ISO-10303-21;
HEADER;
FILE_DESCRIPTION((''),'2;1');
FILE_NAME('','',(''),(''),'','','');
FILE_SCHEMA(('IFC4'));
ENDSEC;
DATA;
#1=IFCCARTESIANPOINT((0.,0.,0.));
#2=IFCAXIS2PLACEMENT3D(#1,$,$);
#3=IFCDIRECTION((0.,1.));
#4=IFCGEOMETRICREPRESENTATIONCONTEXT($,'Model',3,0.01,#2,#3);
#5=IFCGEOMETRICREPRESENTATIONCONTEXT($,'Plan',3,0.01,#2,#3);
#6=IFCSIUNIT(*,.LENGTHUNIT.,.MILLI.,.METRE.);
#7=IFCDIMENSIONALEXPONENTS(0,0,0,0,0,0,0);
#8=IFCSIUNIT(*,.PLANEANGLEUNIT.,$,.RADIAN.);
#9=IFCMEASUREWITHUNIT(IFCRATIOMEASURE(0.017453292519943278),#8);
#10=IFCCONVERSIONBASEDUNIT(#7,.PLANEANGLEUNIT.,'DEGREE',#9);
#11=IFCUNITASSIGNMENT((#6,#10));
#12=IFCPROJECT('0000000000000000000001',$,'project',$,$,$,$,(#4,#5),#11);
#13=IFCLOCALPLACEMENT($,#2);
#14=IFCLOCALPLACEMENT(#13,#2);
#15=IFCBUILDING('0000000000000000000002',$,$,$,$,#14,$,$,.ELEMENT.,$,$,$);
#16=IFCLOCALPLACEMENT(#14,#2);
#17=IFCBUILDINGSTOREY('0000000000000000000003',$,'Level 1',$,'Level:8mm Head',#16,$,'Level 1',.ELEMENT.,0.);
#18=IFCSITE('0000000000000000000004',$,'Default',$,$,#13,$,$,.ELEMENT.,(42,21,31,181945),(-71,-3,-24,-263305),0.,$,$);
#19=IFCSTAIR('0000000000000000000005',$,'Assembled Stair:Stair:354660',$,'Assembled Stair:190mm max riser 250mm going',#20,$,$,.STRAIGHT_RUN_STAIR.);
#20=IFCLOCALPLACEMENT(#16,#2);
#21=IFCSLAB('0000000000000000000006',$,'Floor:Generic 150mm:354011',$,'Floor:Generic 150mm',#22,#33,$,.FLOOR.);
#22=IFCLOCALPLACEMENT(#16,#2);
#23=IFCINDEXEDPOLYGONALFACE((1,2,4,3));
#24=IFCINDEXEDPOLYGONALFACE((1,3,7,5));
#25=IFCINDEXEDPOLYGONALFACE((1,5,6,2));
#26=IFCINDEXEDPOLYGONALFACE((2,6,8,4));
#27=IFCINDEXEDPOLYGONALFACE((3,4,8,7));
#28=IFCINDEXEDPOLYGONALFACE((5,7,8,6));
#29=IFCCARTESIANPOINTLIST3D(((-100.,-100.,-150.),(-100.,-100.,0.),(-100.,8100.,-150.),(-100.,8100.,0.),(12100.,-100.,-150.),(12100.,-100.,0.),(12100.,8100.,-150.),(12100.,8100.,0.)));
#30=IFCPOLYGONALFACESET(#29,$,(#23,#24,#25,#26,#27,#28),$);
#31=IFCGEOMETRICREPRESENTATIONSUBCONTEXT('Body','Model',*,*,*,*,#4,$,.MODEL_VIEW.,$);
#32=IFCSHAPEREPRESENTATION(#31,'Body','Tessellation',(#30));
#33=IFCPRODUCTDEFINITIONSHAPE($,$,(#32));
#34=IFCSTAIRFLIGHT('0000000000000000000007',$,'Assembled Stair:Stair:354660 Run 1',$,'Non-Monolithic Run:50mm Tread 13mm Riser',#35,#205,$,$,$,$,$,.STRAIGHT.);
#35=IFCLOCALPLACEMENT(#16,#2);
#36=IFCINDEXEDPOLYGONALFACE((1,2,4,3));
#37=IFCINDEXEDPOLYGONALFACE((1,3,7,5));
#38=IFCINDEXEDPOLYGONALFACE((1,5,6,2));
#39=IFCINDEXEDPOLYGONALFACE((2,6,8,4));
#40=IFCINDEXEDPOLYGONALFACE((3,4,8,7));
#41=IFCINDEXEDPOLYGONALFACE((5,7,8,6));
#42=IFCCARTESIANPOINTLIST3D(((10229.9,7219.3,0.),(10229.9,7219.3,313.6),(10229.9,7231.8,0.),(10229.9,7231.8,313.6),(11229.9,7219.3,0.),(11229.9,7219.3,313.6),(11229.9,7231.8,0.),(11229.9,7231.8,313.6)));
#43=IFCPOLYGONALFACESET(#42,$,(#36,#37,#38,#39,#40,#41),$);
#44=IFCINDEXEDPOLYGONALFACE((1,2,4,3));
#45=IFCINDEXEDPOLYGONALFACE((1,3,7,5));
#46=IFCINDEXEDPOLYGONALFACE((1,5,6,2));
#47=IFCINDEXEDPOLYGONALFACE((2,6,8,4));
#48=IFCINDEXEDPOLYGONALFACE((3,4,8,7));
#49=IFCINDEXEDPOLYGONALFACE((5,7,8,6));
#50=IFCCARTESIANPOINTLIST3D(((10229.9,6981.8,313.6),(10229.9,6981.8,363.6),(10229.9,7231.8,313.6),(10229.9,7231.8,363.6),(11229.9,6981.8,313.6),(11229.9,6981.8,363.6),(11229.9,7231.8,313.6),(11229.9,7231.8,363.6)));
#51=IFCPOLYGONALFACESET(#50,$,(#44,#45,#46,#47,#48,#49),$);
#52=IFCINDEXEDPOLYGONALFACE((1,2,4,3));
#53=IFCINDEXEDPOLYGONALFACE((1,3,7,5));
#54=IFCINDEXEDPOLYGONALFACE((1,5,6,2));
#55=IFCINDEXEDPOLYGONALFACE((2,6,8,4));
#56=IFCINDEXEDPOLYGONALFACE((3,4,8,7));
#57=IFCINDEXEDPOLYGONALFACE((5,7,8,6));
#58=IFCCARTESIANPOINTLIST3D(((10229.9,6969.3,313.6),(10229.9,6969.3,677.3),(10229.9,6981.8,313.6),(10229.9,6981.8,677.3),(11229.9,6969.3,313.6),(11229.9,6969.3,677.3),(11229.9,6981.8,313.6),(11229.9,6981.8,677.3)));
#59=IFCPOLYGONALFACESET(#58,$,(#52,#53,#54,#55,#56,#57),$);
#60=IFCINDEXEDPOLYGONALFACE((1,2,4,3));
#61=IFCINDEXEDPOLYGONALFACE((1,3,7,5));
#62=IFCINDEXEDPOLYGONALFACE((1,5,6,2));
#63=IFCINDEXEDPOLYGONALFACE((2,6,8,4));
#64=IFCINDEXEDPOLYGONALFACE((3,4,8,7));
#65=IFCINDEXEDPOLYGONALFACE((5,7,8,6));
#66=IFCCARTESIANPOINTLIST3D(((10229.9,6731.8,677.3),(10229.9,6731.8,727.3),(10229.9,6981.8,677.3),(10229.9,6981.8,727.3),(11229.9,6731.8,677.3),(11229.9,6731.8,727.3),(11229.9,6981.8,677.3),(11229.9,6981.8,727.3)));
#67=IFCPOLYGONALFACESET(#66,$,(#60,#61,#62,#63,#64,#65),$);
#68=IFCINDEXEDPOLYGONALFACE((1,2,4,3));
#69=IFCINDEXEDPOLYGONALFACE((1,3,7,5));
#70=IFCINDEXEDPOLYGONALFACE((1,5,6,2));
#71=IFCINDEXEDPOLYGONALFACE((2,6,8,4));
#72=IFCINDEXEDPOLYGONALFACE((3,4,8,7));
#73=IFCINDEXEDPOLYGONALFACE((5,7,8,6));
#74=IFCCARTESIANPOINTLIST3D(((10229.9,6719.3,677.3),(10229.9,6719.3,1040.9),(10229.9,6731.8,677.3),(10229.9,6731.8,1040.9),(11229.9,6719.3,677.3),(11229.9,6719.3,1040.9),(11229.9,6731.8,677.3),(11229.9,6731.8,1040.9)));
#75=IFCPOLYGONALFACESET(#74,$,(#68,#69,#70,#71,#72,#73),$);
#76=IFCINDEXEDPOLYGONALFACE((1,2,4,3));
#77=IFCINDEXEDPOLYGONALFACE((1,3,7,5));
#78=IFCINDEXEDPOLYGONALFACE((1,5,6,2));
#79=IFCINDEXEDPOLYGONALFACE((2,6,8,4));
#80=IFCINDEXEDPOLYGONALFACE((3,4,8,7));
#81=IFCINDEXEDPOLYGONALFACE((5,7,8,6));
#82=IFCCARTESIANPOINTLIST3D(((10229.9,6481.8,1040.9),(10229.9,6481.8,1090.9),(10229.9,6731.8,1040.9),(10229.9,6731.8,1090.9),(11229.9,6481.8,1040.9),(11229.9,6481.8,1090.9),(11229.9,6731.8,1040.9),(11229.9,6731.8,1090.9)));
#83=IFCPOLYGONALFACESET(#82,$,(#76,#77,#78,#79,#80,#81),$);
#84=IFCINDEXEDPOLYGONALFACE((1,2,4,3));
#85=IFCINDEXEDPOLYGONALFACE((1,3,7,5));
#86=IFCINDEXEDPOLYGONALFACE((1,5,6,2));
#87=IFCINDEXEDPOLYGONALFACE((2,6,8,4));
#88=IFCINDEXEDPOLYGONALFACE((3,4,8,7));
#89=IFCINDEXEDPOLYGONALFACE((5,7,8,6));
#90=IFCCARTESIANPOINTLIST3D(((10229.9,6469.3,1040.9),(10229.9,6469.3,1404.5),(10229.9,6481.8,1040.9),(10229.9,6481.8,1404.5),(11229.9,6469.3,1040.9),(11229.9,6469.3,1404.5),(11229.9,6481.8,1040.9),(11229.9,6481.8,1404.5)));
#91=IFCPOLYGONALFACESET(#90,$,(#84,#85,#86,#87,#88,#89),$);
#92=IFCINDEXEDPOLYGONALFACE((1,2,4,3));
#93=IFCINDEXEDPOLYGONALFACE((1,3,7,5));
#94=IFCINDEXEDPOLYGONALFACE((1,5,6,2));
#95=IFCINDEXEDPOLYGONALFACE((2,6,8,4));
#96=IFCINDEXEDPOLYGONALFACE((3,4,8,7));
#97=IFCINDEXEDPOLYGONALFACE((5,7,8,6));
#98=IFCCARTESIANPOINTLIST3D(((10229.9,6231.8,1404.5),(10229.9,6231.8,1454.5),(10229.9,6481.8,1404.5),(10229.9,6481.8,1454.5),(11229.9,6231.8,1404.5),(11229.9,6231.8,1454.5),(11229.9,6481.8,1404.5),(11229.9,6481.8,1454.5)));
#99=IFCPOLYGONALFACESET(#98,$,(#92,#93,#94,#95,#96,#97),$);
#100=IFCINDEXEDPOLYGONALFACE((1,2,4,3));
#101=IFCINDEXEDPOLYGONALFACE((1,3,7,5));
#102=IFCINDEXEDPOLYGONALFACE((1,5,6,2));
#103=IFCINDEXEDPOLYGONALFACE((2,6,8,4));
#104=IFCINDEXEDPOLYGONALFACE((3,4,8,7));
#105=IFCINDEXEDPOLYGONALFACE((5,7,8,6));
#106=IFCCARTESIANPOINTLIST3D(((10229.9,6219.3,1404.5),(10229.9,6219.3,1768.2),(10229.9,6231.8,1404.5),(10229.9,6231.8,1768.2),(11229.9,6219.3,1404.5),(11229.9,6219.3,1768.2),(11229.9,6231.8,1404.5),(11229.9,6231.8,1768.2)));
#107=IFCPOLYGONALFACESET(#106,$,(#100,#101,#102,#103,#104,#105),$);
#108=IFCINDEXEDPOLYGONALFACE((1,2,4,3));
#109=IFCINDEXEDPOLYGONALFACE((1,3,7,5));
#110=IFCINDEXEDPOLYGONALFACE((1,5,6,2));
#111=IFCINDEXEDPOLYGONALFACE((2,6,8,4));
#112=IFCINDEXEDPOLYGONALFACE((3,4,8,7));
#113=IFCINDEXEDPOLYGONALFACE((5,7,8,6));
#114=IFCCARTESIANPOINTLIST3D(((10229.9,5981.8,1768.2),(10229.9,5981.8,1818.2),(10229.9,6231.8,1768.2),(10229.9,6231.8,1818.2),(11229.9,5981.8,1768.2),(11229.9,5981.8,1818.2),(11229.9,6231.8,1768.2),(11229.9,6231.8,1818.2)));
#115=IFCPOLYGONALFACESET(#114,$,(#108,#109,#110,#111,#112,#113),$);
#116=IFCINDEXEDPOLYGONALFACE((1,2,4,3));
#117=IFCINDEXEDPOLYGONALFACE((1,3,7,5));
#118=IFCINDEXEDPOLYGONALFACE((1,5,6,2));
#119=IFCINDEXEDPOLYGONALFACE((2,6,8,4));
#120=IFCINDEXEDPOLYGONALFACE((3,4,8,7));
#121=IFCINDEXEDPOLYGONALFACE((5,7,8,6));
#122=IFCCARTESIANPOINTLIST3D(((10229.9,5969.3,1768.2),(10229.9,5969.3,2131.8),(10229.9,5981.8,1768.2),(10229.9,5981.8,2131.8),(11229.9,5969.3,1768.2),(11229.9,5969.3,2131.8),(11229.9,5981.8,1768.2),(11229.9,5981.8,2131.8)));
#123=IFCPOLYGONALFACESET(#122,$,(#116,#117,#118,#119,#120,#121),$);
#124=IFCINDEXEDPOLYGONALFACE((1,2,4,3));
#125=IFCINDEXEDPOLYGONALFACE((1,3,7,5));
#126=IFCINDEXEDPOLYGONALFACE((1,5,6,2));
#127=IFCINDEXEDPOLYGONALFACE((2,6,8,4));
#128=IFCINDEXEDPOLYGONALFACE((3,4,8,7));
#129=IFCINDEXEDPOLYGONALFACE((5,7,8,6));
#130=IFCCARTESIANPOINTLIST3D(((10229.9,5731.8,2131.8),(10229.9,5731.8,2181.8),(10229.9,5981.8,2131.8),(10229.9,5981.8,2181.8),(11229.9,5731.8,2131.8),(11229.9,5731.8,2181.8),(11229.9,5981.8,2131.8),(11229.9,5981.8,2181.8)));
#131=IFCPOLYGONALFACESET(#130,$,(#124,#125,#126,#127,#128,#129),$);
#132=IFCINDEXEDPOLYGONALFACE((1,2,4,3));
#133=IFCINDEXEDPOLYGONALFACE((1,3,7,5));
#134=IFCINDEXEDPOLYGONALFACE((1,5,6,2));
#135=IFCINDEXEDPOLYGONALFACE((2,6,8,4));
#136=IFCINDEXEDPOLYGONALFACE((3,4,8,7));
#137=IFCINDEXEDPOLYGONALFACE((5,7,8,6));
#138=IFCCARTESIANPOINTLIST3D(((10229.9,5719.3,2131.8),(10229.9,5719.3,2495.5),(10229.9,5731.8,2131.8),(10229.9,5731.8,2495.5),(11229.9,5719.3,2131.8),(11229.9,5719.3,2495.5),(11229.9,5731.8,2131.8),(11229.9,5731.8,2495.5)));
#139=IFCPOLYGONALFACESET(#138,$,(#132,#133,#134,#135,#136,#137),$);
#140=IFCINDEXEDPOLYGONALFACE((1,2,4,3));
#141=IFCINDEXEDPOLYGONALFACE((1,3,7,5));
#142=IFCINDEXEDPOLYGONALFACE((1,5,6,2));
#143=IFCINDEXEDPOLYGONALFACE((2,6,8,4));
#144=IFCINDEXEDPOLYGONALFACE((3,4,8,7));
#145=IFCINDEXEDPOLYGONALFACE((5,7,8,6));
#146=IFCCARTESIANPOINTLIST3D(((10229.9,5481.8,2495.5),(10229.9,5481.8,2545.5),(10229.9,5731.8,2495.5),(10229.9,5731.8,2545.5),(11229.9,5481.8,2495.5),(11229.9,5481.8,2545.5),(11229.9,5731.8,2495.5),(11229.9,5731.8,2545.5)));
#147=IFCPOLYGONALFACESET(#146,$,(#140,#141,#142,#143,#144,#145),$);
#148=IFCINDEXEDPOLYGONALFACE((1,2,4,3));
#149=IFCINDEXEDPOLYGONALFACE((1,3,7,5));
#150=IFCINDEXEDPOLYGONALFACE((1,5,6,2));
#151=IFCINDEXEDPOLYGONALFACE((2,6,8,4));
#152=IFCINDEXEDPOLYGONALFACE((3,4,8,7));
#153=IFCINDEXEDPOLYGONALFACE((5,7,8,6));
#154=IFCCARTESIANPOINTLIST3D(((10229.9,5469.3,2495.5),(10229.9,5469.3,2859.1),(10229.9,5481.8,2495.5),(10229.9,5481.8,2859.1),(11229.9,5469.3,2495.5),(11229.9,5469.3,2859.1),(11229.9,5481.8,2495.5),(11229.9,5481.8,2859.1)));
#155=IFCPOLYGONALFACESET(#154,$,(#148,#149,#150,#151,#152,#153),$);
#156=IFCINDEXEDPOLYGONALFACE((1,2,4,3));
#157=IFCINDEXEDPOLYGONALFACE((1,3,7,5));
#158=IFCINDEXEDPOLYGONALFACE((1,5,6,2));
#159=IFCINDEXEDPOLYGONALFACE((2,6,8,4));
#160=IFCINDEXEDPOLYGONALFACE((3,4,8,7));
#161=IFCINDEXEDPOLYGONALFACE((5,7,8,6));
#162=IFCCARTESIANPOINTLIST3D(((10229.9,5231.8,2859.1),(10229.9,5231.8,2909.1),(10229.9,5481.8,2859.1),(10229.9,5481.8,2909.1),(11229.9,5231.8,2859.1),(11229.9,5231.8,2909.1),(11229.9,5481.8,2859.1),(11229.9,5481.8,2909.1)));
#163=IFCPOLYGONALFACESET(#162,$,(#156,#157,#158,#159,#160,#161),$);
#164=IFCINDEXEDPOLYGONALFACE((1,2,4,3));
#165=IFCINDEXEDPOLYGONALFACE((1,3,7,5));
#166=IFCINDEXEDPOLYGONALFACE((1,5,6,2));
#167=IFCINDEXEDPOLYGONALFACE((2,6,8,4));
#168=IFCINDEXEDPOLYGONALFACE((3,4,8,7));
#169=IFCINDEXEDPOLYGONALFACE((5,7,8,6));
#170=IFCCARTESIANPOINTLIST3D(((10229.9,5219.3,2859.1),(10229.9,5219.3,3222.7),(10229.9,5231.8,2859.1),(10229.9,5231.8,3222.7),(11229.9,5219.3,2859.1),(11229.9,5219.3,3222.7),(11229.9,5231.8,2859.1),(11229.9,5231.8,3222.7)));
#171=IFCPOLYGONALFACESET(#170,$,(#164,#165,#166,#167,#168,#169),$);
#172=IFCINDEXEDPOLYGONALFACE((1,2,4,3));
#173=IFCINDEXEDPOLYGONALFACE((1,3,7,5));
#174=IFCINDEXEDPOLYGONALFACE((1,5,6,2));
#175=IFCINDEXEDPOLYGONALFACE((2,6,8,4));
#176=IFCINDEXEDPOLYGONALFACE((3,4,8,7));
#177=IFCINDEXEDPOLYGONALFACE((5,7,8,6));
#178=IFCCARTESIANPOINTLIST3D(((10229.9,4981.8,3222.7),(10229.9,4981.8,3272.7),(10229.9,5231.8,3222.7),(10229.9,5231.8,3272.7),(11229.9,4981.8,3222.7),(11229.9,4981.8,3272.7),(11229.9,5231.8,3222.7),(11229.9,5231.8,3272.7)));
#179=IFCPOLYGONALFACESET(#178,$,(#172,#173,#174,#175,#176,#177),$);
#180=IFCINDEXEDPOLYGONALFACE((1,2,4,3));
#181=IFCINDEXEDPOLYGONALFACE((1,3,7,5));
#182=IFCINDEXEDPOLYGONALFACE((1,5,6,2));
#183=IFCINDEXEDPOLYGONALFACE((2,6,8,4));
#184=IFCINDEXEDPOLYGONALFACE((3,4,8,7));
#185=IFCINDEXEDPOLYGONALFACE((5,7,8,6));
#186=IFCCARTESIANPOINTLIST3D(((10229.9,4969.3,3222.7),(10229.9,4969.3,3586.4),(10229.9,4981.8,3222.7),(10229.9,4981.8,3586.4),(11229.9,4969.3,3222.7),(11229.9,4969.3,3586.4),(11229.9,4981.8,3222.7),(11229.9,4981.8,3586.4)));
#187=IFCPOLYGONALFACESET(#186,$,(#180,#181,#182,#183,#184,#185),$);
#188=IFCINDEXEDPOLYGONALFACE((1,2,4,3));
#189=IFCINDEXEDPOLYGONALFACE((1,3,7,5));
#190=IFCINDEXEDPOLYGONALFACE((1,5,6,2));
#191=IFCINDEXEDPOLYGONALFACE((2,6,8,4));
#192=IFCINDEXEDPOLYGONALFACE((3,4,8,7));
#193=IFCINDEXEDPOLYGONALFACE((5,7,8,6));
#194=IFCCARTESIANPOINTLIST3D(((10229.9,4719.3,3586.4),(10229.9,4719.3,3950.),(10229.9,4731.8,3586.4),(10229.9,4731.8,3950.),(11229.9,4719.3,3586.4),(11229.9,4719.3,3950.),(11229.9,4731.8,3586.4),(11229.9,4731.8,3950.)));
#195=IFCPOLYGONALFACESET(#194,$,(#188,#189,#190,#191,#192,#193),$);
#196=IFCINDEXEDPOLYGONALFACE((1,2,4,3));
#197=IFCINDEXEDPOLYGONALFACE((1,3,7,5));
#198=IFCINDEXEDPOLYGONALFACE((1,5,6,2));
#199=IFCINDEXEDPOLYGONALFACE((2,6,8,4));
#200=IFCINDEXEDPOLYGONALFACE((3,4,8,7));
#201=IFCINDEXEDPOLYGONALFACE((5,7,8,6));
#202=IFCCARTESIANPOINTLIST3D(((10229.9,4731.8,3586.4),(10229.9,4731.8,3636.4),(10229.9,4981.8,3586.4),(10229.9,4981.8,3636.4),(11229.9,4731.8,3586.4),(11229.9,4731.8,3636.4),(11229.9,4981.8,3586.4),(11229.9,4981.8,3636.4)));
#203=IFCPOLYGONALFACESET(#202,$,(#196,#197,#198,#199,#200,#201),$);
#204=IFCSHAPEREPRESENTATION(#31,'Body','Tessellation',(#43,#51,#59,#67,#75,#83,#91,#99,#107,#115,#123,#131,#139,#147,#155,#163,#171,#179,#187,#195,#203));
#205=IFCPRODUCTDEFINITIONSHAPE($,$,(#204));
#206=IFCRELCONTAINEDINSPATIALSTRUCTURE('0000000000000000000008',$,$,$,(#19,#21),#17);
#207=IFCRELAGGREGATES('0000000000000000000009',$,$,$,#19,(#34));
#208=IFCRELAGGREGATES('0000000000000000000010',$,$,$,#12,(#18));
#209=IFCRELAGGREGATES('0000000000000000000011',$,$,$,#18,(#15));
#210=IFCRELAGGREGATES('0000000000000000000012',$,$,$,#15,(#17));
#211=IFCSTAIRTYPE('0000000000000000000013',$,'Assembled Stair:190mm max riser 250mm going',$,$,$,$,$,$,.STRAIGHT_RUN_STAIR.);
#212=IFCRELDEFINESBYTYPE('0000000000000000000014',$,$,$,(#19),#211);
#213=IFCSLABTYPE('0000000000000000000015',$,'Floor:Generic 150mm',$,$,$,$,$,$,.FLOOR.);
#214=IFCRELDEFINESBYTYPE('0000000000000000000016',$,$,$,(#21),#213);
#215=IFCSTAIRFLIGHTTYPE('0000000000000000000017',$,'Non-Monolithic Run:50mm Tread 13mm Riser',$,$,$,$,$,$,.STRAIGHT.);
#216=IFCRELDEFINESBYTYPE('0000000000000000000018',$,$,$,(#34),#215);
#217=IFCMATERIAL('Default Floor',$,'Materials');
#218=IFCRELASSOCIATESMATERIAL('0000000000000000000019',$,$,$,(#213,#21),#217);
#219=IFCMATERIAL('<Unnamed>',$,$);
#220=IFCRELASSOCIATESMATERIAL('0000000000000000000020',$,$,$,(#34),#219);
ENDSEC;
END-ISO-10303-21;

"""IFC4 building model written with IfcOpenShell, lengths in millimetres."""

from ifc_helpers import new_model, entity, si_unit, converted_unit, direction, frame, origin, place, context, subcontext, project, spatial, indexed_curve, outline, extrude, material, type_object, element, aggregate, save


model = new_model("IFC4")

# Units and contexts
model_context = context("Model", 3, precision=0.01, world=origin(), true_north=direction((0.0, 1.0)))
plan_context = context("Plan", 3, precision=0.01, world=origin(), true_north=direction((0.0, 1.0)))
body_context = subcontext(model_context, "Body", "Model", "MODEL_VIEW")
ifc_project = project(units=[si_unit("LENGTHUNIT", "METRE", prefix="MILLI"), converted_unit("PLANEANGLEUNIT", "DEGREE", entity("IfcRatioMeasure", 0.017453292519943278), si_unit("PLANEANGLEUNIT", "RADIAN"), dimensions=[0, 0, 0, 0, 0, 0, 0])], contexts=[model_context, plan_context])

# Site, building, storey
site_placement = place(None, origin())
site = spatial("IfcSite", under=ifc_project, at=site_placement, Name="Default", CompositionType="ELEMENT", RefLatitude=(42, 21, 31, 181945), RefLongitude=(-71, -3, -24, -263305), RefElevation=0.0)
building_placement = place(site_placement, origin())
building = spatial("IfcBuilding", under=site, at=building_placement, CompositionType="ELEMENT")
storey_placement = place(building_placement, origin())
storey = spatial("IfcBuildingStorey", under=building, at=storey_placement, Name="Level 1", ObjectType="Level:8mm Head", LongName="Level 1", CompositionType="ELEMENT", Elevation=0.0)

# Stair
stair_type = type_object("IfcStairType", Name="Assembled Stair:190mm max riser 250mm going", PredefinedType="STRAIGHT_RUN_STAIR")
stair_placement = place(storey_placement, origin())
stair = element("IfcStair", 1, at=stair_placement, inside=storey, type_object=stair_type, Name="Assembled Stair:Stair:354660", ObjectType="Assembled Stair:190mm max riser 250mm going", PredefinedType="STRAIGHT_RUN_STAIR")
ifc_material_1 = material(Name="<Unnamed>")

# Slab
ifc_material_2 = material(Name="Default Floor", Category="Materials")
slab_type = type_object("IfcSlabType", Name="Floor:Generic 150mm", PredefinedType="FLOOR", material=ifc_material_2)
slab_placement = place(storey_placement, origin())
element("IfcSlab", 2, at=slab_placement, inside=storey, type_object=slab_type, material=ifc_material_2, Name="Floor:Generic 150mm:354011", ObjectType="Floor:Generic 150mm", PredefinedType="FLOOR", context=body_context, shape_type="SweptSolid", body=[
    extrude(outline(indexed_curve([(-4100.0, -6100.0), (4100.0, -6100.0), (4100.0, 6100.0), (-4100.0, 6100.0), (-4100.0, -6100.0)], self_intersect=False)), frame((6000.0, 4000.0, 0.0), z_axis=(0.0, 0.0, -1.0), x_axis=(0.0, 1.0, 0.0)), (0.0, 0.0, 1.0), 150.0),
])

# Stair flight
stair_flight_type = type_object("IfcStairFlightType", Name="Non-Monolithic Run:50mm Tread 13mm Riser", PredefinedType="STRAIGHT")
stair_flight_placement = place(stair_placement, frame((10229.9, 4719.3, 0.0)))
stair_flight = element("IfcStairFlight", 3, at=stair_flight_placement, type_object=stair_flight_type, material=ifc_material_1, Name="Assembled Stair:Stair:354660 Run 1", ObjectType="Non-Monolithic Run:50mm Tread 13mm Riser", PredefinedType="STRAIGHT", context=body_context, shape_type="SweptSolid", body=[
    extrude(outline(indexed_curve([(-500.0, -6.2), (500.0, -6.2), (500.0, 6.3), (-500.0, 6.3), (-500.0, -6.2)], self_intersect=False)), frame((500.0, 2506.2, 0.0)), (0.0, 0.0, 1.0), 313.6),
    extrude(outline(indexed_curve([(-125.0, -500.0), (125.0, -500.0), (125.0, 500.0), (-125.0, 500.0), (-125.0, -500.0)], self_intersect=False)), frame((500.0, 2387.5, 313.6), z_axis=(0.0, 0.0, 1.0), x_axis=(0.0, 1.0, 0.0)), (0.0, 0.0, 1.0), 50.0),
    extrude(outline(indexed_curve([(-500.0, -6.2), (500.0, -6.2), (500.0, 6.3), (-500.0, 6.3), (-500.0, -6.2)], self_intersect=False)), frame((500.0, 2256.2, 313.6)), (0.0, 0.0, 1.0), 363.6),
    extrude(outline(indexed_curve([(-125.0, -500.0), (125.0, -500.0), (125.0, 500.0), (-125.0, 500.0), (-125.0, -500.0)], self_intersect=False)), frame((500.0, 2137.5, 677.3), z_axis=(0.0, 0.0, 1.0), x_axis=(0.0, 1.0, 0.0)), (0.0, 0.0, 1.0), 50.0),
    extrude(outline(indexed_curve([(-500.0, -6.2), (500.0, -6.2), (500.0, 6.3), (-500.0, 6.3), (-500.0, -6.2)], self_intersect=False)), frame((500.0, 2006.2, 677.3)), (0.0, 0.0, 1.0), 363.6),
    extrude(outline(indexed_curve([(-125.0, -500.0), (125.0, -500.0), (125.0, 500.0), (-125.0, 500.0), (-125.0, -500.0)], self_intersect=False)), frame((500.0, 1887.5, 1040.9), z_axis=(0.0, 0.0, 1.0), x_axis=(0.0, 1.0, 0.0)), (0.0, 0.0, 1.0), 50.0),
    extrude(outline(indexed_curve([(-500.0, -6.2), (500.0, -6.2), (500.0, 6.3), (-500.0, 6.3), (-500.0, -6.2)], self_intersect=False)), frame((500.0, 1756.2, 1040.9)), (0.0, 0.0, 1.0), 363.6),
    extrude(outline(indexed_curve([(-125.0, -500.0), (125.0, -500.0), (125.0, 500.0), (-125.0, 500.0), (-125.0, -500.0)], self_intersect=False)), frame((500.0, 1637.5, 1404.5), z_axis=(0.0, 0.0, 1.0), x_axis=(0.0, 1.0, 0.0)), (0.0, 0.0, 1.0), 50.0),
    extrude(outline(indexed_curve([(-500.0, -6.2), (500.0, -6.2), (500.0, 6.3), (-500.0, 6.3), (-500.0, -6.2)], self_intersect=False)), frame((500.0, 1506.2, 1404.5)), (0.0, 0.0, 1.0), 363.6),
    extrude(outline(indexed_curve([(-125.0, -500.0), (125.0, -500.0), (125.0, 500.0), (-125.0, 500.0), (-125.0, -500.0)], self_intersect=False)), frame((500.0, 1387.5, 1768.2), z_axis=(0.0, 0.0, 1.0), x_axis=(0.0, 1.0, 0.0)), (0.0, 0.0, 1.0), 50.0),
    extrude(outline(indexed_curve([(-500.0, -6.3), (500.0, -6.3), (500.0, 6.2), (-500.0, 6.2), (-500.0, -6.3)], self_intersect=False)), frame((500.0, 1256.3, 1768.2)), (0.0, 0.0, 1.0), 363.6),
    extrude(outline(indexed_curve([(-125.0, -500.0), (125.0, -500.0), (125.0, 500.0), (-125.0, 500.0), (-125.0, -500.0)], self_intersect=False)), frame((500.0, 1137.5, 2131.8), z_axis=(0.0, 0.0, 1.0), x_axis=(0.0, 1.0, 0.0)), (0.0, 0.0, 1.0), 50.0),
    extrude(outline(indexed_curve([(-500.0, -6.3), (500.0, -6.3), (500.0, 6.2), (-500.0, 6.2), (-500.0, -6.3)], self_intersect=False)), frame((500.0, 1006.3, 2131.8)), (0.0, 0.0, 1.0), 363.6),
    extrude(outline(indexed_curve([(-125.0, -500.0), (125.0, -500.0), (125.0, 500.0), (-125.0, 500.0), (-125.0, -500.0)], self_intersect=False)), frame((500.0, 887.5, 2495.5), z_axis=(0.0, 0.0, 1.0), x_axis=(0.0, 1.0, 0.0)), (0.0, 0.0, 1.0), 50.0),
    extrude(outline(indexed_curve([(-500.0, -6.2), (500.0, -6.2), (500.0, 6.3), (-500.0, 6.3), (-500.0, -6.2)], self_intersect=False)), frame((500.0, 756.2, 2495.5)), (0.0, 0.0, 1.0), 363.6),
    extrude(outline(indexed_curve([(-125.0, -500.0), (125.0, -500.0), (125.0, 500.0), (-125.0, 500.0), (-125.0, -500.0)], self_intersect=False)), frame((500.0, 637.5, 2859.1), z_axis=(0.0, 0.0, 1.0), x_axis=(0.0, 1.0, 0.0)), (0.0, 0.0, 1.0), 50.0),
    extrude(outline(indexed_curve([(-500.0, -6.2), (500.0, -6.2), (500.0, 6.3), (-500.0, 6.3), (-500.0, -6.2)], self_intersect=False)), frame((500.0, 506.2, 2859.1)), (0.0, 0.0, 1.0), 363.6),
    extrude(outline(indexed_curve([(-125.0, -500.0), (125.0, -500.0), (125.0, 500.0), (-125.0, 500.0), (-125.0, -500.0)], self_intersect=False)), frame((500.0, 387.5, 3222.7), z_axis=(0.0, 0.0, 1.0), x_axis=(0.0, 1.0, 0.0)), (0.0, 0.0, 1.0), 50.0),
    extrude(outline(indexed_curve([(-500.0, -6.2), (500.0, -6.2), (500.0, 6.3), (-500.0, 6.3), (-500.0, -6.2)], self_intersect=False)), frame((500.0, 256.2, 3222.7)), (0.0, 0.0, 1.0), 363.6),
    extrude(outline(indexed_curve([(-500.0, -6.2), (500.0, -6.2), (500.0, 6.3), (-500.0, 6.3), (-500.0, -6.2)], self_intersect=False)), frame((500.0, 6.2, 3586.4)), (0.0, 0.0, 1.0), 363.6),
    extrude(outline(indexed_curve([(-125.0, -500.0), (125.0, -500.0), (125.0, 500.0), (-125.0, 500.0), (-125.0, -500.0)], self_intersect=False)), frame((500.0, 137.5, 3586.4), z_axis=(0.0, 0.0, 1.0), x_axis=(0.0, 1.0, 0.0)), (0.0, 0.0, 1.0), 50.0),
])

aggregate(stair, [stair_flight])

save(model, "model.ifc")
